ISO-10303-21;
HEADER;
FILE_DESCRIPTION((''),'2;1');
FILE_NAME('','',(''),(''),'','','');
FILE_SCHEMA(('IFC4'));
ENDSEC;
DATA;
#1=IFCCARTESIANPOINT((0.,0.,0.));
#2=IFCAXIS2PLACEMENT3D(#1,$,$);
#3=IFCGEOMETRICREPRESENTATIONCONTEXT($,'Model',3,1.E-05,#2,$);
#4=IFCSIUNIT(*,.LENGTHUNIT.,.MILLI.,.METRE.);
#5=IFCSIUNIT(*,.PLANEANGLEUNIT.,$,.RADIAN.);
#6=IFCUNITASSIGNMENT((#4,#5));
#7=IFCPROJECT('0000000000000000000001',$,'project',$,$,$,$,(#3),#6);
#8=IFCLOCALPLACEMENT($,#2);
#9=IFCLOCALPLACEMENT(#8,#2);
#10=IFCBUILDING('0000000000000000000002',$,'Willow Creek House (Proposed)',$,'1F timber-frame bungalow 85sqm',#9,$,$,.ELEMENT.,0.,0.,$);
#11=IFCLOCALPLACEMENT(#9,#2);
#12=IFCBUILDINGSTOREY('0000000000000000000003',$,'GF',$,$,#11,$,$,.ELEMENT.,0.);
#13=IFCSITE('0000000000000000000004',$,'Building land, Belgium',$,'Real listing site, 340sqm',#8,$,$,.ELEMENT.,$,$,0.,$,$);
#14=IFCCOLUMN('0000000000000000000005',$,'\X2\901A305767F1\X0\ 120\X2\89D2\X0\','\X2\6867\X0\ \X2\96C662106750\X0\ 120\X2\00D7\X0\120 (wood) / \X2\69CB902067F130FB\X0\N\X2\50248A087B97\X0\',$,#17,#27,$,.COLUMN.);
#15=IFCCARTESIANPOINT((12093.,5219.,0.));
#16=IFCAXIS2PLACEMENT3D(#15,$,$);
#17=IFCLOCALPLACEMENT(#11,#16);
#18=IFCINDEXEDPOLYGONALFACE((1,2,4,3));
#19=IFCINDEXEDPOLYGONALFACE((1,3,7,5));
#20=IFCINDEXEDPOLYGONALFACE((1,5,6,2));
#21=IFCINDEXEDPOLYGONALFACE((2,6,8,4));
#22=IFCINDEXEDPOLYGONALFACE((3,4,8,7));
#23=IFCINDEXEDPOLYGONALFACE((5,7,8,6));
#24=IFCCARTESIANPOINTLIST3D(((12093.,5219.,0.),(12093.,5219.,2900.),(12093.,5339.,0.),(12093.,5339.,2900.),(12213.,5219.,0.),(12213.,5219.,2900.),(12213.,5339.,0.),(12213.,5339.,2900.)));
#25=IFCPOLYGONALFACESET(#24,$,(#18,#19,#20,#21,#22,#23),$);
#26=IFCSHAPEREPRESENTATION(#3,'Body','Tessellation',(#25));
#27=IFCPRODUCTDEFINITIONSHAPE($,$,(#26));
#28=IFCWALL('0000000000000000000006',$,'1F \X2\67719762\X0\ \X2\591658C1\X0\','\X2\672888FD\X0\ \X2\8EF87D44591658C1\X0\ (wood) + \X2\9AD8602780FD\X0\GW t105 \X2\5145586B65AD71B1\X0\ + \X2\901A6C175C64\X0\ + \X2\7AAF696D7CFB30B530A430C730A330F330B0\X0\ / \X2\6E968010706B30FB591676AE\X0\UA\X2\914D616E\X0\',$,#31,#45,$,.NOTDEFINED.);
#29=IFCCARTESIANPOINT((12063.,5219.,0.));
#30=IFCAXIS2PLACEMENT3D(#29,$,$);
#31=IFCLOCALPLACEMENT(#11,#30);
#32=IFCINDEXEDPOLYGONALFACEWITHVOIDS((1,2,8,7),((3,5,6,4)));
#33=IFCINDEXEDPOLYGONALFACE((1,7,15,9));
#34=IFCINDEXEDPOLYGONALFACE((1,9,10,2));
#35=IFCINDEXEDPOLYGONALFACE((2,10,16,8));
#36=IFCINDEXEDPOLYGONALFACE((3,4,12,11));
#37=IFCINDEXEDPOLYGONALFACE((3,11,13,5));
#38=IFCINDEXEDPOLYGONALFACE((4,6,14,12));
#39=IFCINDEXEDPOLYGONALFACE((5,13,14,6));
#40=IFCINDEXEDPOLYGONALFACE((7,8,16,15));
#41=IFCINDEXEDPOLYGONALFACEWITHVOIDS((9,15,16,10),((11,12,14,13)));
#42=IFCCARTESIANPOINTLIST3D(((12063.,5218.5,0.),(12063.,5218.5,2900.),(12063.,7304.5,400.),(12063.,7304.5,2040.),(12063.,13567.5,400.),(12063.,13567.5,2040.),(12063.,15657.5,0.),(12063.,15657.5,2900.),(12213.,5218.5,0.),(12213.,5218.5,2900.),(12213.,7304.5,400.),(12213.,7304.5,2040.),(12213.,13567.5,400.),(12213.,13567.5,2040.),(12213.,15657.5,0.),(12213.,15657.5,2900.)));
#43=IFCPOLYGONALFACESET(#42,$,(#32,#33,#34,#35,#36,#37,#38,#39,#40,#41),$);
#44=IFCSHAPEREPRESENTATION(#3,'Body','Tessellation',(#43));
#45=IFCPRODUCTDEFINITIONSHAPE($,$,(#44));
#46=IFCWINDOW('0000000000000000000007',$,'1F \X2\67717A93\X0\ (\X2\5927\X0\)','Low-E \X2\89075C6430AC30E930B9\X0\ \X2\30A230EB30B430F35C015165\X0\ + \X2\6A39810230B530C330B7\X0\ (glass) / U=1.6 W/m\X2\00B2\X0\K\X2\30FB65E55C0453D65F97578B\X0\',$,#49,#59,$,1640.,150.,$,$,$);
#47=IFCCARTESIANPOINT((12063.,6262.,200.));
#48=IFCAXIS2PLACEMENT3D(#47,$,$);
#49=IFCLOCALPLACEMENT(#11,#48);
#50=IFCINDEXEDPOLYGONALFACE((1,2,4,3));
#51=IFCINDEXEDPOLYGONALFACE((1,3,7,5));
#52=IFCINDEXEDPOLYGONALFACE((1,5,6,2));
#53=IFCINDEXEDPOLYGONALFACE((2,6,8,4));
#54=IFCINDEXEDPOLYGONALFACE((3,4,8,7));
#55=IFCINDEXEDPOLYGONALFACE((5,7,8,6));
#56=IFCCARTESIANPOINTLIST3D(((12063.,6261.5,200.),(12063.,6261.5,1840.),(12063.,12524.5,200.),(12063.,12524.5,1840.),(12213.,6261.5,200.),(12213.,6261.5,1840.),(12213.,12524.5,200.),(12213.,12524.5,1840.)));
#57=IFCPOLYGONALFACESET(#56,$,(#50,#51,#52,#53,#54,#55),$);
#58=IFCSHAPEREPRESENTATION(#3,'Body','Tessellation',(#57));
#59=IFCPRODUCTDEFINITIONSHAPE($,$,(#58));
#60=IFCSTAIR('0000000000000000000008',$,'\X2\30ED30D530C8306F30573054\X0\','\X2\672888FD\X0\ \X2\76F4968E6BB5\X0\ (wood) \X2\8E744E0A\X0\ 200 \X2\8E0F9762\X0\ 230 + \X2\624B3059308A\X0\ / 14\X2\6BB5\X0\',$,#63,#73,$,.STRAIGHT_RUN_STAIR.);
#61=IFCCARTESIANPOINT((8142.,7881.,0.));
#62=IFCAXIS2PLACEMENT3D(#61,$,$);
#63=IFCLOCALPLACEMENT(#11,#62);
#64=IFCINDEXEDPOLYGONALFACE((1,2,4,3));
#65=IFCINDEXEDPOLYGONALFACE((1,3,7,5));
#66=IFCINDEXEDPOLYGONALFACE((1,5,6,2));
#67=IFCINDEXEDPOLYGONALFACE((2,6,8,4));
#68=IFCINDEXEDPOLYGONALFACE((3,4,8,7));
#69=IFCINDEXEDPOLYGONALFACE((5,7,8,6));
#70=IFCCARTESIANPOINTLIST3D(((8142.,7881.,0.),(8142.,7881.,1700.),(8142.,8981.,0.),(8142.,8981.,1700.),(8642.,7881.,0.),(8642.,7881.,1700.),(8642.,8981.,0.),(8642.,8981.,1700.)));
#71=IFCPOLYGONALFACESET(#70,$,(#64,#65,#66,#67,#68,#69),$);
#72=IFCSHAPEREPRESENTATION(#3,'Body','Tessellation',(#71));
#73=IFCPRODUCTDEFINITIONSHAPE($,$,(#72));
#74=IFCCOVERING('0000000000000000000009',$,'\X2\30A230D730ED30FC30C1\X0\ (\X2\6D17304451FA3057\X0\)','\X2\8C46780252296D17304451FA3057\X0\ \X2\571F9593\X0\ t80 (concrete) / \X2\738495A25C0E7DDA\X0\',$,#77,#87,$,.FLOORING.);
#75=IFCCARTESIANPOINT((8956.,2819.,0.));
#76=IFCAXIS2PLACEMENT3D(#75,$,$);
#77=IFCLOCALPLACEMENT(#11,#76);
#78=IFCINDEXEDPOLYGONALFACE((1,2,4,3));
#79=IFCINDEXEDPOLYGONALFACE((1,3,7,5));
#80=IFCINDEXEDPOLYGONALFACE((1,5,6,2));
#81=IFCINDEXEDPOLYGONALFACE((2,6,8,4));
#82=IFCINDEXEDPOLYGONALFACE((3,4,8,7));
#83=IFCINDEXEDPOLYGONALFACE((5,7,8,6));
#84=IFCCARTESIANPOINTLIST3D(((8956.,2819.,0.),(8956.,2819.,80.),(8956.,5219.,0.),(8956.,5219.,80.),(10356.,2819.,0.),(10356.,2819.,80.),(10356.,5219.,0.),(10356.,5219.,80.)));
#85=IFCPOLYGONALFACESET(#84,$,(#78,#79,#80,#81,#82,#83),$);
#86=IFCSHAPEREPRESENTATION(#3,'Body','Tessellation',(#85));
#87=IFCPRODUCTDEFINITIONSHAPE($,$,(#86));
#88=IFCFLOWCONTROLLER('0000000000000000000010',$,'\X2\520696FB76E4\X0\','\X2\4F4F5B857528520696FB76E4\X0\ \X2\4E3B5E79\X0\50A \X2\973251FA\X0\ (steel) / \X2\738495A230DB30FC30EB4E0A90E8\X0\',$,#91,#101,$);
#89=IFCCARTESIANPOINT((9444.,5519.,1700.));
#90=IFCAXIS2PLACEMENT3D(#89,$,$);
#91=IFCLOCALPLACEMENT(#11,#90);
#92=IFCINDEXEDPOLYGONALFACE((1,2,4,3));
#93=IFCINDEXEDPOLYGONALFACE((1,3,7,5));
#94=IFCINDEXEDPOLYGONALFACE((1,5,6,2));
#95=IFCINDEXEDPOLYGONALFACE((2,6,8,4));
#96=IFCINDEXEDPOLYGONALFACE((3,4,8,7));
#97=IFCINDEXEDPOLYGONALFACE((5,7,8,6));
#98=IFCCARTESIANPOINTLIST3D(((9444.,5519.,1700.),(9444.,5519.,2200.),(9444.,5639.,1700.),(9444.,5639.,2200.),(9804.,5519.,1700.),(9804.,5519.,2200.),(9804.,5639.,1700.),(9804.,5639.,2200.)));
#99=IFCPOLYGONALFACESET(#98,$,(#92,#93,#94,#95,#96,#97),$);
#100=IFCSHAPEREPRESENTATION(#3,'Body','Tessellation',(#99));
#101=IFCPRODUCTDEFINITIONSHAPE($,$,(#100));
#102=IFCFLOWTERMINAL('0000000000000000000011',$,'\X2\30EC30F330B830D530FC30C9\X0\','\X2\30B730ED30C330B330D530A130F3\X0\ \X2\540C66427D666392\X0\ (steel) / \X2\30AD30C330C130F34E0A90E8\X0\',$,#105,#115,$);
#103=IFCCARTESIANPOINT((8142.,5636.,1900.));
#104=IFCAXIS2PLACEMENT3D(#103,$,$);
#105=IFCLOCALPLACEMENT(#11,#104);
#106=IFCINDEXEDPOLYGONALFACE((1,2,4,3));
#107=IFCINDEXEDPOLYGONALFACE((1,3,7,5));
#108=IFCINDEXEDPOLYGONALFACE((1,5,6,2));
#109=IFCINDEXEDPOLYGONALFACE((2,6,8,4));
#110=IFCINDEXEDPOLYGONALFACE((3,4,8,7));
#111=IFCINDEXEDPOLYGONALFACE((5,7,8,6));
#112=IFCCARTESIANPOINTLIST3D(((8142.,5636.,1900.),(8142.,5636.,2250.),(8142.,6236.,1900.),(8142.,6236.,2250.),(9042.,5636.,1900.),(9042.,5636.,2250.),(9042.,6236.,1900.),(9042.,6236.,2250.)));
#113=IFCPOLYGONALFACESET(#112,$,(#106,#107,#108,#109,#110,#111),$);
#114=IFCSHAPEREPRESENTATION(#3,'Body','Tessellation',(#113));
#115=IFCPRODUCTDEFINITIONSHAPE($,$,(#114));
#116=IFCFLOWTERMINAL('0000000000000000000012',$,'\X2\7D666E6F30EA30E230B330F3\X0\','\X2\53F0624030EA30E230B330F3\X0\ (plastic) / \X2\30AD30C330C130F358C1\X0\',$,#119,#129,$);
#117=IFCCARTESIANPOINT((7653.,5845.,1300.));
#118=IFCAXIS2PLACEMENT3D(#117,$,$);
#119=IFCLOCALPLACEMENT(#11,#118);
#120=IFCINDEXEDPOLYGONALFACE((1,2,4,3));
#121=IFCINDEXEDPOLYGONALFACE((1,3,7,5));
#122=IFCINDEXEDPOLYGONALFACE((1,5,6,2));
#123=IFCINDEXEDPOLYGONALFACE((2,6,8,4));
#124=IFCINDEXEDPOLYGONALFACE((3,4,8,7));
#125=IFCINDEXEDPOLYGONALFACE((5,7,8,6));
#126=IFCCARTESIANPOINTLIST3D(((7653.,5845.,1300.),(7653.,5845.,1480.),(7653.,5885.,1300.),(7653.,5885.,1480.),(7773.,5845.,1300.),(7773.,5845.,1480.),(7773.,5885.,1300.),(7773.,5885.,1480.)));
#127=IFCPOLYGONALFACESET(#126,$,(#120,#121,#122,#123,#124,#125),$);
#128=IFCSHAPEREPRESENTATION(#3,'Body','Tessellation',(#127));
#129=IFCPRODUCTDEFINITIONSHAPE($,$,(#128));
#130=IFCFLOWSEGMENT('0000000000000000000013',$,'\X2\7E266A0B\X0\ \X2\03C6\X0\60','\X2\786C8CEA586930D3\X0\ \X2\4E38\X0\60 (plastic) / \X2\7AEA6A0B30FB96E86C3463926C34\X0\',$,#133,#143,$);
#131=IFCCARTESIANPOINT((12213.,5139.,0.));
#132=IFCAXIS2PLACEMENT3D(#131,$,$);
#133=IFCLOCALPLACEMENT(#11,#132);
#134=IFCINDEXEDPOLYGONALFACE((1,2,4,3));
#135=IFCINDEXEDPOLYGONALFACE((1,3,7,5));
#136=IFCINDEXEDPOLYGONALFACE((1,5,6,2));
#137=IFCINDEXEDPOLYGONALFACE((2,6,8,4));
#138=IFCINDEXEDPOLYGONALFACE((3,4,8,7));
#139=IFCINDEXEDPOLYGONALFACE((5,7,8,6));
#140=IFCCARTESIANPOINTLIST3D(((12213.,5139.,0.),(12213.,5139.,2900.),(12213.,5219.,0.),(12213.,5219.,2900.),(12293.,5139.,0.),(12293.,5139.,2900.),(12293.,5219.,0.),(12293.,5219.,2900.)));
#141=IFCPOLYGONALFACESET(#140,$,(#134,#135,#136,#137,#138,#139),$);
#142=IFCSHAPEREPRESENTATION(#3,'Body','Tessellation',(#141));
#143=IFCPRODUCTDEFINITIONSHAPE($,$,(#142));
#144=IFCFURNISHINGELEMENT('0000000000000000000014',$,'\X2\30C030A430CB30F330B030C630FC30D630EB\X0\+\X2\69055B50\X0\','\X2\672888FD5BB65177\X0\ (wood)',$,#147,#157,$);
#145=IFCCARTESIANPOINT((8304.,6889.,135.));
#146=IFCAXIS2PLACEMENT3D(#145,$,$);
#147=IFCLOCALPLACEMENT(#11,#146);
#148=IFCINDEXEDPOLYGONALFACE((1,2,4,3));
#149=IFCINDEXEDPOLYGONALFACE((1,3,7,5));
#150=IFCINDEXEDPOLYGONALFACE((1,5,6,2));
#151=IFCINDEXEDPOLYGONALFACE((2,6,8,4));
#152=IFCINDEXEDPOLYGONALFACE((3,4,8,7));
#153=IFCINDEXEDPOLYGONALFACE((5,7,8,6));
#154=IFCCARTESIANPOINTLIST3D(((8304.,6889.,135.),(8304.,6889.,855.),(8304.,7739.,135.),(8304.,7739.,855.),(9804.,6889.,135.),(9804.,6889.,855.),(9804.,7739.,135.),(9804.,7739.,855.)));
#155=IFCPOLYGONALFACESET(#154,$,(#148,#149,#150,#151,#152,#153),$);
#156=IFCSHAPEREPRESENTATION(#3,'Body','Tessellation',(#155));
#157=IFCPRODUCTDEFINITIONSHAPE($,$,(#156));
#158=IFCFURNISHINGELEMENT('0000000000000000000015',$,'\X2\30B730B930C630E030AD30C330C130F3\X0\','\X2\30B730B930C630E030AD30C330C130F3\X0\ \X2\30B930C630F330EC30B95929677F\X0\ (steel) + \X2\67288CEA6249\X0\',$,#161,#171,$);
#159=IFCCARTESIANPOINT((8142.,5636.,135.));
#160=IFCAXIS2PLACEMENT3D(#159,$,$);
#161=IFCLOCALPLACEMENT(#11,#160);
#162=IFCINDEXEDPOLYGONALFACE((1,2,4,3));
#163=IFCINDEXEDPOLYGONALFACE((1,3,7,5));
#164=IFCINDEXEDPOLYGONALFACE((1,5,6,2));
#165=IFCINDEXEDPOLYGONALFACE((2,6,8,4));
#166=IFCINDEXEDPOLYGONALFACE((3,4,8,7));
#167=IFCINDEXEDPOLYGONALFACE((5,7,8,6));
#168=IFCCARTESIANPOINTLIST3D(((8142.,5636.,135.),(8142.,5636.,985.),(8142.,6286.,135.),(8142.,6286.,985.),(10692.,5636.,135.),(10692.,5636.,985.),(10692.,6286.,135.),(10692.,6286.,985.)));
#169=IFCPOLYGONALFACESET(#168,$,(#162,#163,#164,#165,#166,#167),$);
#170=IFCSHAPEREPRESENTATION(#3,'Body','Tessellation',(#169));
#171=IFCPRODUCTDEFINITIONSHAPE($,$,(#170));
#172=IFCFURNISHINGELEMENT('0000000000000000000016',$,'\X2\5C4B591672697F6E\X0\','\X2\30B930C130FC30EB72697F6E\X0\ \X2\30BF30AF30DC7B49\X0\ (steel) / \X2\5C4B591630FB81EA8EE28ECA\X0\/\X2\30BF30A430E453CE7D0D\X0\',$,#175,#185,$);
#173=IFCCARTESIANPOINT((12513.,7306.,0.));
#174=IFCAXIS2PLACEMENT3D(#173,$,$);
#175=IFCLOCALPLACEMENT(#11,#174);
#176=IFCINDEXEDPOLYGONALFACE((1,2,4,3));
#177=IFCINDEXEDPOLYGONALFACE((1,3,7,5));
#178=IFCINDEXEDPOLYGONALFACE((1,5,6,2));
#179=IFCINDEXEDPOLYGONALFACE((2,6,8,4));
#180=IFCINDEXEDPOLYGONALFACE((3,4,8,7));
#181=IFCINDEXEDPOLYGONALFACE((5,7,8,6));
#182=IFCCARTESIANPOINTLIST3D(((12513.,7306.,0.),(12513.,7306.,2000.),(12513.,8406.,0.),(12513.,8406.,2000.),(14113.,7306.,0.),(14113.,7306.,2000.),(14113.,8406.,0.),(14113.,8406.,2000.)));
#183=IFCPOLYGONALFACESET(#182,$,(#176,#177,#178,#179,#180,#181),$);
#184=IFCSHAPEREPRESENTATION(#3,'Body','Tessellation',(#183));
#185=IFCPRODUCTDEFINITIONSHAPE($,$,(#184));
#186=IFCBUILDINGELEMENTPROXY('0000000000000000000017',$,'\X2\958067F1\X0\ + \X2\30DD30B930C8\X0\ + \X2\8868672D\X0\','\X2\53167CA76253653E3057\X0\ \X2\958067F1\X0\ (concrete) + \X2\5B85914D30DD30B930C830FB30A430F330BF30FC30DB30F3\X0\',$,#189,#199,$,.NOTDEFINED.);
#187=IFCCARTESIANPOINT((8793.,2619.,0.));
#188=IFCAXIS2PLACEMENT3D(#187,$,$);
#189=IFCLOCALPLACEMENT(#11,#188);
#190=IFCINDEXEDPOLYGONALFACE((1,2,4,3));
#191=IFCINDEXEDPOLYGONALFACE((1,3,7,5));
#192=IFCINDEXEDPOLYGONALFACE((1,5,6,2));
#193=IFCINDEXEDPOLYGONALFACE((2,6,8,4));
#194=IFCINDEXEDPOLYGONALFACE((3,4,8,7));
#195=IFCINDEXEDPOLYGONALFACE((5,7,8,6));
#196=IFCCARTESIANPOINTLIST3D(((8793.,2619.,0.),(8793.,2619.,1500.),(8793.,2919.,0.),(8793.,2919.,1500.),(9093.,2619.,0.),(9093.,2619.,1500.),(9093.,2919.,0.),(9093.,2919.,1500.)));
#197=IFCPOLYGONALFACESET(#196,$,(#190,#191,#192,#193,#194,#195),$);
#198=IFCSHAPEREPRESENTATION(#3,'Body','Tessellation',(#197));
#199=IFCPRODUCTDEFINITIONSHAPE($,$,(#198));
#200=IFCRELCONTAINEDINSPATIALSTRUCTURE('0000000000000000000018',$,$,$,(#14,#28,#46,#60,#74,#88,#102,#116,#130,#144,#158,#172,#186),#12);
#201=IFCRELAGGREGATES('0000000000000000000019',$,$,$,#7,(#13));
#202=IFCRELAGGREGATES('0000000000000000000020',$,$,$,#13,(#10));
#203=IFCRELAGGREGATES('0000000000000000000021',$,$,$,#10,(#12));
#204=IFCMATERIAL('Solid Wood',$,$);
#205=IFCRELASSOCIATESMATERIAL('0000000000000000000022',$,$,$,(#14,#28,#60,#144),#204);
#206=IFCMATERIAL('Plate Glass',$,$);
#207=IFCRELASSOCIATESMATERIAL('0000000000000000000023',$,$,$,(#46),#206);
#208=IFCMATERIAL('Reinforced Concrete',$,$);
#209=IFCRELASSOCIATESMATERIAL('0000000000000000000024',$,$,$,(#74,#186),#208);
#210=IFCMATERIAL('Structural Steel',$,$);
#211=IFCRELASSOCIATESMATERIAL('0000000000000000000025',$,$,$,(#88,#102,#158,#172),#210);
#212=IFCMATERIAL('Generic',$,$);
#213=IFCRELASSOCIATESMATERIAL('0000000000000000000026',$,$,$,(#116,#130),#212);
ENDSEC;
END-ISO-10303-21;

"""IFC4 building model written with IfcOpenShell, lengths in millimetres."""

from ifc_helpers import new_model, si_unit, frame, frame_2d, origin, place, context, project, spatial, rectangle, extrude, material, element, fill, save


model = new_model("IFC4")

# Units and contexts
model_context = context("Model", 3, precision=1e-05, world=origin())
ifc_project = project(units=[si_unit("LENGTHUNIT", "METRE", prefix="MILLI"), si_unit("PLANEANGLEUNIT", "RADIAN")], contexts=[model_context])

# Site, building, storey
site_placement = place(None, origin())
site = spatial("IfcSite", under=ifc_project, at=site_placement, Name="Building land, Belgium", ObjectType="Real listing site, 340sqm", CompositionType="ELEMENT", RefElevation=0.0)
building_placement = place(site_placement, origin())
building = spatial("IfcBuilding", under=site, at=building_placement, Name="Willow Creek House (Proposed)", ObjectType="1F timber-frame bungalow 85sqm", CompositionType="ELEMENT", ElevationOfRefHeight=0.0, ElevationOfTerrain=0.0)
storey_placement = place(building_placement, origin())
storey = spatial("IfcBuildingStorey", under=building, at=storey_placement, Name="GF", CompositionType="ELEMENT", Elevation=0.0)

# Column
ifc_material_1 = material(Name="Solid Wood")
column_1_placement = place(storey_placement, frame((12093.0, 5219.0, 0.0)))
element("IfcColumn", 1, at=column_1_placement, inside=storey, material=ifc_material_1, Name="通し柱 120角", Description="桧 集成材 120×120 (wood) / 構造柱・N値計算", PredefinedType="COLUMN", context=model_context, shape_type="SweptSolid", body=[
    extrude(rectangle(XDim=120.0, YDim=120.0, at=frame_2d((60.0, 60.0))), frame((12093.0, 5219.0, 0.0)), (0.0, 0.0, 1.0), 2900.0),
])

# Wall, opening, window
wall_1_placement = place(storey_placement, frame((12063.0, 5219.0, 0.0)))
wall_1 = element("IfcWall", 2, at=wall_1_placement, inside=storey, material=ifc_material_1, Name="1F 東面 外壁", Description="木製 軸組外壁 (wood) + 高性能GW t105 充填断熱 + 通気層 + 窯業系サイディング / 準耐火・外皮UA配慮", PredefinedType="NOTDEFINED", context=model_context, shape_type="SweptSolid", body=[
    extrude(rectangle(XDim=150.0, YDim=10439.0, at=frame_2d((75.0, 5219.0))), frame((12063.0, 5219.0, 0.0)), (0.0, 0.0, 1.0), 2900.0),
])
opening_placement = place(storey_placement, frame((12063.0, 6262.0, 200.0)))
opening = element("IfcOpeningElement", 3, at=opening_placement, cuts=wall_1, PredefinedType="NOTDEFINED", context=model_context, shape_type="SweptSolid", body=[
    extrude(rectangle(XDim=150.0, YDim=6263.0, at=frame_2d((75.0, 3131.0))), frame((12063.0, 6262.0, 200.0)), (0.0, 0.0, 1.0), 1640.0),
])
ifc_material_2 = material(Name="Plate Glass")
window_placement = place(storey_placement, frame((12063.0, 6262.0, 200.0)))
window = element("IfcWindow", 4, at=window_placement, inside=storey, material=ifc_material_2, Name="1F 東窓 (大)", Description="Low-E 複層ガラス アルゴン封入 + 樹脂サッシ (glass) / U=1.6 W/m²K・日射取得型", OverallHeight=1640.0, OverallWidth=150.0, context=model_context, shape_type="SweptSolid", body=[
    extrude(rectangle(XDim=150.0, YDim=6263.0, at=frame_2d((75.0, 3131.0))), frame((12063.0, 6262.0, 200.0)), (0.0, 0.0, 1.0), 1640.0),
])
fill(opening, window)

# Stair
stair_placement = place(storey_placement, frame((8142.0, 7881.0, 0.0)))
element("IfcStair", 5, at=stair_placement, inside=storey, material=ifc_material_1, Name="ロフトはしご", Description="木製 直階段 (wood) 蹴上 200 踏面 230 + 手すり / 14段", PredefinedType="STRAIGHT_RUN_STAIR", context=model_context, shape_type="SweptSolid", body=[
    extrude(rectangle(XDim=500.0, YDim=1100.0, at=frame_2d((250.0, 550.0))), frame((8142.0, 7881.0, 0.0)), (0.0, 0.0, 1.0), 1700.0),
])

# Covering
ifc_material_3 = material(Name="Reinforced Concrete")
covering_placement = place(storey_placement, frame((8956.0, 2819.0, 0.0)))
element("IfcCovering", 6, at=covering_placement, inside=storey, material=ifc_material_3, Name="アプローチ (洗い出し)", Description="豆砂利洗い出し 土間 t80 (concrete) / 玄関導線", PredefinedType="FLOORING", context=model_context, shape_type="SweptSolid", body=[
    extrude(rectangle(XDim=1400.0, YDim=2400.0, at=frame_2d((700.0, 1200.0))), frame((8956.0, 2819.0, 0.0)), (0.0, 0.0, 1.0), 80.0),
])

# Flow controller
ifc_material_4 = material(Name="Structural Steel")
flow_controller_placement = place(storey_placement, frame((9444.0, 5519.0, 1700.0)))
element("IfcFlowController", 7, at=flow_controller_placement, inside=storey, material=ifc_material_4, Name="分電盤", Description="住宅用分電盤 主幹50A 露出 (steel) / 玄関ホール上部", context=model_context, shape_type="SweptSolid", body=[
    extrude(rectangle(XDim=360.0, YDim=120.0, at=frame_2d((180.0, 60.0))), frame((9444.0, 5519.0, 1700.0)), (0.0, 0.0, 1.0), 500.0),
])

# Flow terminals
flow_terminal_1_placement = place(storey_placement, frame((8142.0, 5636.0, 1900.0)))
element("IfcFlowTerminal", 8, at=flow_terminal_1_placement, inside=storey, material=ifc_material_4, Name="レンジフード", Description="シロッコファン 同時給排 (steel) / キッチン上部", context=model_context, shape_type="SweptSolid", body=[
    extrude(rectangle(XDim=900.0, YDim=600.0, at=frame_2d((450.0, 300.0))), frame((8142.0, 5636.0, 1900.0)), (0.0, 0.0, 1.0), 350.0),
])
ifc_material_5 = material(Name="Generic")
flow_terminal_2_placement = place(storey_placement, frame((7653.0, 5845.0, 1300.0)))
element("IfcFlowTerminal", 9, at=flow_terminal_2_placement, inside=storey, material=ifc_material_5, Name="給湯リモコン", Description="台所リモコン (plastic) / キッチン壁", context=model_context, shape_type="SweptSolid", body=[
    extrude(rectangle(XDim=120.0, YDim=40.0, at=frame_2d((60.0, 20.0))), frame((7653.0, 5845.0, 1300.0)), (0.0, 0.0, 1.0), 180.0),
])

# Flow segment
flow_segment_placement = place(storey_placement, frame((12213.0, 5139.0, 0.0)))
element("IfcFlowSegment", 10, at=flow_segment_placement, inside=storey, material=ifc_material_5, Name="縦樋 φ60", Description="硬質塩ビ 丸60 (plastic) / 竪樋・雨水排水", context=model_context, shape_type="SweptSolid", body=[
    extrude(rectangle(XDim=80.0, YDim=80.0, at=frame_2d((40.0, 40.0))), frame((12213.0, 5139.0, 0.0)), (0.0, 0.0, 1.0), 2900.0),
])

# Furnishing elements
furnishing_1_placement = place(storey_placement, frame((8304.0, 6889.0, 135.0)))
element("IfcFurnishingElement", 11, at=furnishing_1_placement, inside=storey, material=ifc_material_1, Name="ダイニングテーブル+椅子", Description="木製家具 (wood)", context=model_context, shape_type="SweptSolid", body=[
    extrude(rectangle(XDim=1500.0, YDim=850.0, at=frame_2d((750.0, 425.0))), frame((8304.0, 6889.0, 135.0)), (0.0, 0.0, 1.0), 720.0),
])
furnishing_2_placement = place(storey_placement, frame((8142.0, 5636.0, 135.0)))
element("IfcFurnishingElement", 12, at=furnishing_2_placement, inside=storey, material=ifc_material_4, Name="システムキッチン", Description="システムキッチン ステンレス天板 (steel) + 木質扉", context=model_context, shape_type="SweptSolid", body=[
    extrude(rectangle(XDim=2550.0, YDim=650.0, at=frame_2d((1275.0, 325.0))), frame((8142.0, 5636.0, 135.0)), (0.0, 0.0, 1.0), 850.0),
])
furnishing_3_placement = place(storey_placement, frame((12513.0, 7306.0, 0.0)))
element("IfcFurnishingElement", 13, at=furnishing_3_placement, inside=storey, material=ifc_material_4, Name="屋外物置", Description="スチール物置 タクボ等 (steel) / 屋外・自転車/タイヤ収納", context=model_context, shape_type="SweptSolid", body=[
    extrude(rectangle(XDim=1600.0, YDim=1100.0, at=frame_2d((800.0, 550.0))), frame((12513.0, 7306.0, 0.0)), (0.0, 0.0, 1.0), 2000.0),
])

# Building element proxy
proxy_placement = place(storey_placement, frame((8793.0, 2619.0, 0.0)))
element("IfcBuildingElementProxy", 14, at=proxy_placement, inside=storey, material=ifc_material_3, Name="門柱 + ポスト + 表札", Description="化粧打放し 門柱 (concrete) + 宅配ポスト・インターホン", PredefinedType="NOTDEFINED", context=model_context, shape_type="SweptSolid", body=[
    extrude(rectangle(XDim=300.0, YDim=300.0, at=frame_2d((150.0, 150.0))), frame((8793.0, 2619.0, 0.0)), (0.0, 0.0, 1.0), 1500.0),
])

save(model, "model.ifc")
